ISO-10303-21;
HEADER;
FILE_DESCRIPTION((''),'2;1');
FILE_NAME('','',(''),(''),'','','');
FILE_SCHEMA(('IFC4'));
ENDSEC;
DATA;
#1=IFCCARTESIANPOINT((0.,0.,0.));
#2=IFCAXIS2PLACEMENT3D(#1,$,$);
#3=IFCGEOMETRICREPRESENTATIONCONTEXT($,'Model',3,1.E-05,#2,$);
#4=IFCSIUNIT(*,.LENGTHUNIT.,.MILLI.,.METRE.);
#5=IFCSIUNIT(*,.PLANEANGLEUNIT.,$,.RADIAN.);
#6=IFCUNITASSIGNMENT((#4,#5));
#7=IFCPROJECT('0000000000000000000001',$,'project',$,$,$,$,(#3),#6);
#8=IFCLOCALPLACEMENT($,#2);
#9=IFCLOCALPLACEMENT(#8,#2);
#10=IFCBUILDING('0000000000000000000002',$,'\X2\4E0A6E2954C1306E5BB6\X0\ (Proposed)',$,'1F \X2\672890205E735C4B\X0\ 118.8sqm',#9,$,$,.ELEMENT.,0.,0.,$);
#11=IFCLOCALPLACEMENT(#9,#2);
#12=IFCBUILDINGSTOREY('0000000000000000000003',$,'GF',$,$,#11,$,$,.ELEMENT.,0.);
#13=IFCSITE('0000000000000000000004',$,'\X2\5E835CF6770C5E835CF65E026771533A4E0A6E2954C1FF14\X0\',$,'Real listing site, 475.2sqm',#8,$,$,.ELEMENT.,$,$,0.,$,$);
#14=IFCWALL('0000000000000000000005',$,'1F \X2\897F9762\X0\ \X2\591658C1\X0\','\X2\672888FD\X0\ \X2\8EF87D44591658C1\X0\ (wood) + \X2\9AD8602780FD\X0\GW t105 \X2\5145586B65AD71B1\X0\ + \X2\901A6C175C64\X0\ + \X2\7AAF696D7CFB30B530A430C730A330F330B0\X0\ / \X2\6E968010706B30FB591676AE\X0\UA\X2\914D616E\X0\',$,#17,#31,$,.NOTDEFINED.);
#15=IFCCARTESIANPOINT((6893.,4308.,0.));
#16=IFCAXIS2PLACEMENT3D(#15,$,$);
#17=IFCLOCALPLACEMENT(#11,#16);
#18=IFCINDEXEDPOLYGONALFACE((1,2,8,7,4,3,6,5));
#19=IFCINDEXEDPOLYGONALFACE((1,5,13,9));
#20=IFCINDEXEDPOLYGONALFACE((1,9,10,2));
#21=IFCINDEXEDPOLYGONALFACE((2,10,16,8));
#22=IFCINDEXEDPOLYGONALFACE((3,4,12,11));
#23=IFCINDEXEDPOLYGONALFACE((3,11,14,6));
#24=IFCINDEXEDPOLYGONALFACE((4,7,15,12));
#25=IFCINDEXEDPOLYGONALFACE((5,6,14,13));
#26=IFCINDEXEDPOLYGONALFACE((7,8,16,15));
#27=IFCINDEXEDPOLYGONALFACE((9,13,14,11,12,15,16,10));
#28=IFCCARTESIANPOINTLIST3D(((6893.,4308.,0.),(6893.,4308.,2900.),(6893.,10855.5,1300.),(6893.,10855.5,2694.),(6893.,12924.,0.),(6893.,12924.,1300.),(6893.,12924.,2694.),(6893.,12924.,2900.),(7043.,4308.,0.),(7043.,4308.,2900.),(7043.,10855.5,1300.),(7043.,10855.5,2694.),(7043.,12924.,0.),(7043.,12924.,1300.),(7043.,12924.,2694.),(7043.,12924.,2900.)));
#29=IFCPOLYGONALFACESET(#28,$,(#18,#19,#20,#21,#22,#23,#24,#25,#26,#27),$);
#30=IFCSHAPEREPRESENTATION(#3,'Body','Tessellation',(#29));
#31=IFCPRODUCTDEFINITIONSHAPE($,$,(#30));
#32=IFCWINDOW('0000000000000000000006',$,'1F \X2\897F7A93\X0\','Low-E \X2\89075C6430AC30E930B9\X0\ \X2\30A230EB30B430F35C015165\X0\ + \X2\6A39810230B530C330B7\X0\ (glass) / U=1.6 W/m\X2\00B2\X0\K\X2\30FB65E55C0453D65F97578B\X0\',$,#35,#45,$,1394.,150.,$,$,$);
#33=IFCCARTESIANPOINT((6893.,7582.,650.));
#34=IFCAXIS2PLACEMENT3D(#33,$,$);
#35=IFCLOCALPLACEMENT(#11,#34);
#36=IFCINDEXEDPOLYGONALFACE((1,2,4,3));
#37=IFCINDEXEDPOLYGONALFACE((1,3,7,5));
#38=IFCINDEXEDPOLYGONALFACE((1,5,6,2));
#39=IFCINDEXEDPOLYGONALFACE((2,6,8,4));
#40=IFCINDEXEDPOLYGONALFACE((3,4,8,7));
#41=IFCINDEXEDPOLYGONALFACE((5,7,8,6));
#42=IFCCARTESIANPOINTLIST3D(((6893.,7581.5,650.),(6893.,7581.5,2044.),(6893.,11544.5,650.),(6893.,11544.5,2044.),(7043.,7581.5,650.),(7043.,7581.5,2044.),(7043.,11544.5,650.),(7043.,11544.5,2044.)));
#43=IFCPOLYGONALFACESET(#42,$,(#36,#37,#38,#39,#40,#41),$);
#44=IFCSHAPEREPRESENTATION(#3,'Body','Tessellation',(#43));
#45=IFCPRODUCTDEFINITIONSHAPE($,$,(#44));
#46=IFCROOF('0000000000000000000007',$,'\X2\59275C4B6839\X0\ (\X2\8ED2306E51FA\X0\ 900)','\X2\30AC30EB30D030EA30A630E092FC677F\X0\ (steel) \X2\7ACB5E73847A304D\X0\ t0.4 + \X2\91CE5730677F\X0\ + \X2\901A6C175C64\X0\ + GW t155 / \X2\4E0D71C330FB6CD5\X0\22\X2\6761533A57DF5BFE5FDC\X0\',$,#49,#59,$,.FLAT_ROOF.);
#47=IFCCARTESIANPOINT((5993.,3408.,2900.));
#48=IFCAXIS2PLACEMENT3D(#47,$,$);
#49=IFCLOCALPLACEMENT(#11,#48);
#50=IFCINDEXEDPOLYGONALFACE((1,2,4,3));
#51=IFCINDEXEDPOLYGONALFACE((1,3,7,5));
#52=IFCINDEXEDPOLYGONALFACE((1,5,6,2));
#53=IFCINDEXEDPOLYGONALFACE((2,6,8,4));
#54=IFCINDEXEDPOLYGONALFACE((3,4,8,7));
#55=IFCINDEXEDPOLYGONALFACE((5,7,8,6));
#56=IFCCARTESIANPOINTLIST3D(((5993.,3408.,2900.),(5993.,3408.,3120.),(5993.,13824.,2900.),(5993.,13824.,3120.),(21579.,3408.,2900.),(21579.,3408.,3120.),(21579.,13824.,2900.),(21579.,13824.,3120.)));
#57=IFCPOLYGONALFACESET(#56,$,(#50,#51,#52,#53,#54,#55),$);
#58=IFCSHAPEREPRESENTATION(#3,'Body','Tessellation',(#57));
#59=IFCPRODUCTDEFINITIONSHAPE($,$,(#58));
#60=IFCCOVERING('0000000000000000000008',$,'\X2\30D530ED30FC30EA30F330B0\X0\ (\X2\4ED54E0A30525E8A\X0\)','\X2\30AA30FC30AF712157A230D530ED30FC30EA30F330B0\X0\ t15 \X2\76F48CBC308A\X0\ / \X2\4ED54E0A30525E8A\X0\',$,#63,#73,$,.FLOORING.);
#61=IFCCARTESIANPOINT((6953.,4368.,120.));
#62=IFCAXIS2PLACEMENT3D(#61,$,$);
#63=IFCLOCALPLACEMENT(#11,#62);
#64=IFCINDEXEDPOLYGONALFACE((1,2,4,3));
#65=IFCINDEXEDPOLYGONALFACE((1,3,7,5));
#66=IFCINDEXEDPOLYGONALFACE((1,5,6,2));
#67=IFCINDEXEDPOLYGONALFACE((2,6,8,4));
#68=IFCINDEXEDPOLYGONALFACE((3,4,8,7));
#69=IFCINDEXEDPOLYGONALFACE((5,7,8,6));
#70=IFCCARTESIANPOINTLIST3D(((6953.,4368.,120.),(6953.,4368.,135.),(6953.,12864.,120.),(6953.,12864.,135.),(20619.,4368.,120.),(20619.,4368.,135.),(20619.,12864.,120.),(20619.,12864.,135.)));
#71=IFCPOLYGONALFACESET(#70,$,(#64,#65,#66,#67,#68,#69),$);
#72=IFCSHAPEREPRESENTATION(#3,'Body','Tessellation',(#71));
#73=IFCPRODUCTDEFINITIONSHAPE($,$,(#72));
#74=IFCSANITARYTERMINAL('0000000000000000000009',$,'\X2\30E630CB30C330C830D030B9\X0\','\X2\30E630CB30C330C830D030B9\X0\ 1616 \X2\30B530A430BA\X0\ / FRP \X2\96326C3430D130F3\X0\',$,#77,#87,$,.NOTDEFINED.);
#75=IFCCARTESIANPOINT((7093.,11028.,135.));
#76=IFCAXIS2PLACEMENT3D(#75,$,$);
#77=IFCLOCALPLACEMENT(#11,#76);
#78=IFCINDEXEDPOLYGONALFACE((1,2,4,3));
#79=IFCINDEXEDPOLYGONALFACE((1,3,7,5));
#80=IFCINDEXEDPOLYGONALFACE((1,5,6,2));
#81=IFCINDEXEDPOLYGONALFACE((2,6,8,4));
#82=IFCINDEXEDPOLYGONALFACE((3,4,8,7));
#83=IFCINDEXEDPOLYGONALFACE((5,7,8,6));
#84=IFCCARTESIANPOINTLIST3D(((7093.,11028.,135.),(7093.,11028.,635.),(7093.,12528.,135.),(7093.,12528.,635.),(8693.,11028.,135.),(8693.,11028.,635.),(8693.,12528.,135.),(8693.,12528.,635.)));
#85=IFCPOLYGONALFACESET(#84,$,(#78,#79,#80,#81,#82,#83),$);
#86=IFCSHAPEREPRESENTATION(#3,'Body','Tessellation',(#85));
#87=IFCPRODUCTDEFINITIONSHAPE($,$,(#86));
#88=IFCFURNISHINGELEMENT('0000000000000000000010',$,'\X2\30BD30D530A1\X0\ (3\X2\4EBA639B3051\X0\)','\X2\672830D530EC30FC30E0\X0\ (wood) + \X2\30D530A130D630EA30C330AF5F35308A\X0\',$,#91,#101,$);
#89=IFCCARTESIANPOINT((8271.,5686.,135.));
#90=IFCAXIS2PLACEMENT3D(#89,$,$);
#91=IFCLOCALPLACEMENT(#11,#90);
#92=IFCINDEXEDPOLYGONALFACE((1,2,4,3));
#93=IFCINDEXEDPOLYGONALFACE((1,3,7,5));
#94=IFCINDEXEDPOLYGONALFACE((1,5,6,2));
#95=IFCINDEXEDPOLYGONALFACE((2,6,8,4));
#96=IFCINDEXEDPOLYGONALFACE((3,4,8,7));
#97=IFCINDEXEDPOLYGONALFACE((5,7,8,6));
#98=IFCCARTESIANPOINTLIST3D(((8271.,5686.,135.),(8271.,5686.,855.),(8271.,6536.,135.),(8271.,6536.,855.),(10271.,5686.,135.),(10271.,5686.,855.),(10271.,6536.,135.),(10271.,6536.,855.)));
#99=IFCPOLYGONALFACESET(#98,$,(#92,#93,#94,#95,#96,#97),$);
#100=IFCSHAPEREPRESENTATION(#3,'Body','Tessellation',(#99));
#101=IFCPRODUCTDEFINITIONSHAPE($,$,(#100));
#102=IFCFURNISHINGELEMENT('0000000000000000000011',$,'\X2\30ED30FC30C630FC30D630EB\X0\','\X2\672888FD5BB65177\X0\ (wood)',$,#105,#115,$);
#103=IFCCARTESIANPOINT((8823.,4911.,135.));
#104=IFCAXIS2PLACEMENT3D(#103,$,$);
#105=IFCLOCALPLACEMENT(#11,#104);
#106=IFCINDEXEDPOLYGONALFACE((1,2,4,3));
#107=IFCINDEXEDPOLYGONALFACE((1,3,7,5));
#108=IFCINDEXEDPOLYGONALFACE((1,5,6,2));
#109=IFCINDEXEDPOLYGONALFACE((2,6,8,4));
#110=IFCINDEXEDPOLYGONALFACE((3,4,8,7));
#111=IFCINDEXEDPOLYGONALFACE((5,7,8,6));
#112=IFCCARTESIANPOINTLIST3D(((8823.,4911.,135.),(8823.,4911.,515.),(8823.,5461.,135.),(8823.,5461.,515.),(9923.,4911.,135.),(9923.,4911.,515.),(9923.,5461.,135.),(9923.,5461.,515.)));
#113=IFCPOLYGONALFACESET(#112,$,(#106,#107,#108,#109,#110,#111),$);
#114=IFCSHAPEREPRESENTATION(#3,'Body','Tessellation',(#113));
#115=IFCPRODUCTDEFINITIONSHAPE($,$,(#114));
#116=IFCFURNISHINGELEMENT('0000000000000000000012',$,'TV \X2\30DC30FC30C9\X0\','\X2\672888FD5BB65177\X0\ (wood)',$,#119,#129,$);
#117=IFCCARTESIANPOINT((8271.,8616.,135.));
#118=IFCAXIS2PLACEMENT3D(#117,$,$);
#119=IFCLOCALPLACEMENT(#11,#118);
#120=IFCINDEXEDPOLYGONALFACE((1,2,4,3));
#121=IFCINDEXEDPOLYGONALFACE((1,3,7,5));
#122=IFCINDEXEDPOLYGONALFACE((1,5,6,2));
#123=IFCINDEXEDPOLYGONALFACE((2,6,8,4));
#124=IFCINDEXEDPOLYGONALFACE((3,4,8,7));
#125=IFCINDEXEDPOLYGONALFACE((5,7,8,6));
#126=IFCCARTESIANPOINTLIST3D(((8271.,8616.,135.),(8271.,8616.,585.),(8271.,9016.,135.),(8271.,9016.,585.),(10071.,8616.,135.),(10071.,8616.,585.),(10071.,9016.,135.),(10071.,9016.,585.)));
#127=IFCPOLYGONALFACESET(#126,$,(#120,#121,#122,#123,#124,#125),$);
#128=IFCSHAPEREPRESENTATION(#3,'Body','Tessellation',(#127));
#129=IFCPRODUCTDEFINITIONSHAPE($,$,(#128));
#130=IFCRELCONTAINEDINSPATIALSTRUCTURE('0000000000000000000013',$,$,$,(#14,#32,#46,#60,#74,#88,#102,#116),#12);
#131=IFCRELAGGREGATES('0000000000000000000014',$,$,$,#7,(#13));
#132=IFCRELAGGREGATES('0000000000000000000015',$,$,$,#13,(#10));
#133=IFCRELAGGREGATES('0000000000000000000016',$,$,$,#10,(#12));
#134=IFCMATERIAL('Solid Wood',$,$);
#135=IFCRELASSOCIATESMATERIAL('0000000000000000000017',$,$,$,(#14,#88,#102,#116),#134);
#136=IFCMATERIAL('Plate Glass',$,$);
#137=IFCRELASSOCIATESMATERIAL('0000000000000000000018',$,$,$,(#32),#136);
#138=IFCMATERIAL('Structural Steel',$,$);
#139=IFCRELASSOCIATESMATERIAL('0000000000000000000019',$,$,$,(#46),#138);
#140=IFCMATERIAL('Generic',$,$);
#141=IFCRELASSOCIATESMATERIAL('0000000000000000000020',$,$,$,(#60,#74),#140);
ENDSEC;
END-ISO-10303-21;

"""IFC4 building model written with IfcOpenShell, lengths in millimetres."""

from ifc_helpers import new_model, si_unit, frame, frame_2d, origin, place, context, project, spatial, rectangle, extrude, material, element, fill, save


model = new_model("IFC4")

# Units and contexts
model_context = context("Model", 3, precision=1e-05, world=origin())
ifc_project = project(units=[si_unit("LENGTHUNIT", "METRE", prefix="MILLI"), si_unit("PLANEANGLEUNIT", "RADIAN")], contexts=[model_context])

# Site, building, storey
site_placement = place(None, origin())
site = spatial("IfcSite", under=ifc_project, at=site_placement, Name="広島県広島市東区上温品４", ObjectType="Real listing site, 475.2sqm", CompositionType="ELEMENT", RefElevation=0.0)
building_placement = place(site_placement, origin())
building = spatial("IfcBuilding", under=site, at=building_placement, Name="上温品の家 (Proposed)", ObjectType="1F 木造平屋 118.8sqm", CompositionType="ELEMENT", ElevationOfRefHeight=0.0, ElevationOfTerrain=0.0)
storey_placement = place(building_placement, origin())
storey = spatial("IfcBuildingStorey", under=building, at=storey_placement, Name="GF", CompositionType="ELEMENT", Elevation=0.0)

# Shared definitions
ifc_material_1 = material(Name="Solid Wood")

# Shared definitions
ifc_material_2 = material(Name="Plate Glass")

# Wall, opening, window
wall_1_placement = place(storey_placement, frame((6893.0, 4308.0, 0.0)))
wall_1 = element("IfcWall", 1, at=wall_1_placement, inside=storey, material=ifc_material_1, Name="1F 西面 外壁", Description="木製 軸組外壁 (wood) + 高性能GW t105 充填断熱 + 通気層 + 窯業系サイディング / 準耐火・外皮UA配慮", PredefinedType="NOTDEFINED", context=model_context, shape_type="SweptSolid", body=[
    extrude(rectangle(XDim=150.0, YDim=8616.0, at=frame_2d((75.0, 4308.0))), frame((6893.0, 4308.0, 0.0)), (0.0, 0.0, 1.0), 2900.0),
])
opening_1_placement = place(storey_placement, frame((6893.0, 7582.0, 650.0)))
opening_1 = element("IfcOpeningElement", 2, at=opening_1_placement, cuts=wall_1, PredefinedType="NOTDEFINED", context=model_context, shape_type="SweptSolid", body=[
    extrude(rectangle(XDim=150.0, YDim=3963.0, at=frame_2d((75.0, 1981.0))), frame((6893.0, 7582.0, 650.0)), (0.0, 0.0, 1.0), 1394.0),
])
window_1_placement = place(storey_placement, frame((6893.0, 7582.0, 650.0)))
window_1 = element("IfcWindow", 3, at=window_1_placement, inside=storey, material=ifc_material_2, Name="1F 西窓", Description="Low-E 複層ガラス アルゴン封入 + 樹脂サッシ (glass) / U=1.6 W/m²K・日射取得型", OverallHeight=1394.0, OverallWidth=150.0, context=model_context, shape_type="SweptSolid", body=[
    extrude(rectangle(XDim=150.0, YDim=3963.0, at=frame_2d((75.0, 1981.0))), frame((6893.0, 7582.0, 650.0)), (0.0, 0.0, 1.0), 1394.0),
])
fill(opening_1, window_1)

# Roof
ifc_material_3 = material(Name="Structural Steel")
roof_placement = place(storey_placement, frame((5993.0, 3408.0, 2900.0)))
element("IfcRoof", 4, at=roof_placement, inside=storey, material=ifc_material_3, Name="大屋根 (軒の出 900)", Description="ガルバリウム鋼板 (steel) 立平葺き t0.4 + 野地板 + 通気層 + GW t155 / 不燃・法22条区域対応", PredefinedType="FLAT_ROOF", context=model_context, shape_type="SweptSolid", body=[
    extrude(rectangle(XDim=15586.0, YDim=10416.0, at=frame_2d((7793.0, 5208.0))), frame((5993.0, 3408.0, 2900.0)), (0.0, 0.0, 1.0), 220.0),
])

# Covering
ifc_material_4 = material(Name="Generic")
covering_placement = place(storey_placement, frame((6953.0, 4368.0, 120.0)))
element("IfcCovering", 5, at=covering_placement, inside=storey, material=ifc_material_4, Name="フローリング (仕上げ床)", Description="オーク無垢フローリング t15 直貼り / 仕上げ床", PredefinedType="FLOORING", context=model_context, shape_type="SweptSolid", body=[
    extrude(rectangle(XDim=13666.0, YDim=8496.0, at=frame_2d((6833.0, 4248.0))), frame((6953.0, 4368.0, 120.0)), (0.0, 0.0, 1.0), 15.0),
])

# Sanitary terminal
sanitary_terminal_placement = place(storey_placement, frame((7093.0, 11028.0, 135.0)))
element("IfcSanitaryTerminal", 6, at=sanitary_terminal_placement, inside=storey, material=ifc_material_4, Name="ユニットバス", Description="ユニットバス 1616 サイズ / FRP 防水パン", PredefinedType="NOTDEFINED", context=model_context, shape_type="SweptSolid", body=[
    extrude(rectangle(XDim=1600.0, YDim=1500.0, at=frame_2d((800.0, 750.0))), frame((7093.0, 11028.0, 135.0)), (0.0, 0.0, 1.0), 500.0),
])

# Furnishing elements
furnishing_1_placement = place(storey_placement, frame((8271.0, 5686.0, 135.0)))
element("IfcFurnishingElement", 7, at=furnishing_1_placement, inside=storey, material=ifc_material_1, Name="ソファ (3人掛け)", Description="木フレーム (wood) + ファブリック張り", context=model_context, shape_type="SweptSolid", body=[
    extrude(rectangle(XDim=2000.0, YDim=850.0, at=frame_2d((1000.0, 425.0))), frame((8271.0, 5686.0, 135.0)), (0.0, 0.0, 1.0), 720.0),
])
furnishing_2_placement = place(storey_placement, frame((8823.0, 4911.0, 135.0)))
element("IfcFurnishingElement", 8, at=furnishing_2_placement, inside=storey, material=ifc_material_1, Name="ローテーブル", Description="木製家具 (wood)", context=model_context, shape_type="SweptSolid", body=[
    extrude(rectangle(XDim=1100.0, YDim=550.0, at=frame_2d((550.0, 275.0))), frame((8823.0, 4911.0, 135.0)), (0.0, 0.0, 1.0), 380.0),
])
furnishing_3_placement = place(storey_placement, frame((8271.0, 8616.0, 135.0)))
element("IfcFurnishingElement", 9, at=furnishing_3_placement, inside=storey, material=ifc_material_1, Name="TV ボード", Description="木製家具 (wood)", context=model_context, shape_type="SweptSolid", body=[
    extrude(rectangle(XDim=1800.0, YDim=400.0, at=frame_2d((900.0, 200.0))), frame((8271.0, 8616.0, 135.0)), (0.0, 0.0, 1.0), 450.0),
])

save(model, "model.ifc")
